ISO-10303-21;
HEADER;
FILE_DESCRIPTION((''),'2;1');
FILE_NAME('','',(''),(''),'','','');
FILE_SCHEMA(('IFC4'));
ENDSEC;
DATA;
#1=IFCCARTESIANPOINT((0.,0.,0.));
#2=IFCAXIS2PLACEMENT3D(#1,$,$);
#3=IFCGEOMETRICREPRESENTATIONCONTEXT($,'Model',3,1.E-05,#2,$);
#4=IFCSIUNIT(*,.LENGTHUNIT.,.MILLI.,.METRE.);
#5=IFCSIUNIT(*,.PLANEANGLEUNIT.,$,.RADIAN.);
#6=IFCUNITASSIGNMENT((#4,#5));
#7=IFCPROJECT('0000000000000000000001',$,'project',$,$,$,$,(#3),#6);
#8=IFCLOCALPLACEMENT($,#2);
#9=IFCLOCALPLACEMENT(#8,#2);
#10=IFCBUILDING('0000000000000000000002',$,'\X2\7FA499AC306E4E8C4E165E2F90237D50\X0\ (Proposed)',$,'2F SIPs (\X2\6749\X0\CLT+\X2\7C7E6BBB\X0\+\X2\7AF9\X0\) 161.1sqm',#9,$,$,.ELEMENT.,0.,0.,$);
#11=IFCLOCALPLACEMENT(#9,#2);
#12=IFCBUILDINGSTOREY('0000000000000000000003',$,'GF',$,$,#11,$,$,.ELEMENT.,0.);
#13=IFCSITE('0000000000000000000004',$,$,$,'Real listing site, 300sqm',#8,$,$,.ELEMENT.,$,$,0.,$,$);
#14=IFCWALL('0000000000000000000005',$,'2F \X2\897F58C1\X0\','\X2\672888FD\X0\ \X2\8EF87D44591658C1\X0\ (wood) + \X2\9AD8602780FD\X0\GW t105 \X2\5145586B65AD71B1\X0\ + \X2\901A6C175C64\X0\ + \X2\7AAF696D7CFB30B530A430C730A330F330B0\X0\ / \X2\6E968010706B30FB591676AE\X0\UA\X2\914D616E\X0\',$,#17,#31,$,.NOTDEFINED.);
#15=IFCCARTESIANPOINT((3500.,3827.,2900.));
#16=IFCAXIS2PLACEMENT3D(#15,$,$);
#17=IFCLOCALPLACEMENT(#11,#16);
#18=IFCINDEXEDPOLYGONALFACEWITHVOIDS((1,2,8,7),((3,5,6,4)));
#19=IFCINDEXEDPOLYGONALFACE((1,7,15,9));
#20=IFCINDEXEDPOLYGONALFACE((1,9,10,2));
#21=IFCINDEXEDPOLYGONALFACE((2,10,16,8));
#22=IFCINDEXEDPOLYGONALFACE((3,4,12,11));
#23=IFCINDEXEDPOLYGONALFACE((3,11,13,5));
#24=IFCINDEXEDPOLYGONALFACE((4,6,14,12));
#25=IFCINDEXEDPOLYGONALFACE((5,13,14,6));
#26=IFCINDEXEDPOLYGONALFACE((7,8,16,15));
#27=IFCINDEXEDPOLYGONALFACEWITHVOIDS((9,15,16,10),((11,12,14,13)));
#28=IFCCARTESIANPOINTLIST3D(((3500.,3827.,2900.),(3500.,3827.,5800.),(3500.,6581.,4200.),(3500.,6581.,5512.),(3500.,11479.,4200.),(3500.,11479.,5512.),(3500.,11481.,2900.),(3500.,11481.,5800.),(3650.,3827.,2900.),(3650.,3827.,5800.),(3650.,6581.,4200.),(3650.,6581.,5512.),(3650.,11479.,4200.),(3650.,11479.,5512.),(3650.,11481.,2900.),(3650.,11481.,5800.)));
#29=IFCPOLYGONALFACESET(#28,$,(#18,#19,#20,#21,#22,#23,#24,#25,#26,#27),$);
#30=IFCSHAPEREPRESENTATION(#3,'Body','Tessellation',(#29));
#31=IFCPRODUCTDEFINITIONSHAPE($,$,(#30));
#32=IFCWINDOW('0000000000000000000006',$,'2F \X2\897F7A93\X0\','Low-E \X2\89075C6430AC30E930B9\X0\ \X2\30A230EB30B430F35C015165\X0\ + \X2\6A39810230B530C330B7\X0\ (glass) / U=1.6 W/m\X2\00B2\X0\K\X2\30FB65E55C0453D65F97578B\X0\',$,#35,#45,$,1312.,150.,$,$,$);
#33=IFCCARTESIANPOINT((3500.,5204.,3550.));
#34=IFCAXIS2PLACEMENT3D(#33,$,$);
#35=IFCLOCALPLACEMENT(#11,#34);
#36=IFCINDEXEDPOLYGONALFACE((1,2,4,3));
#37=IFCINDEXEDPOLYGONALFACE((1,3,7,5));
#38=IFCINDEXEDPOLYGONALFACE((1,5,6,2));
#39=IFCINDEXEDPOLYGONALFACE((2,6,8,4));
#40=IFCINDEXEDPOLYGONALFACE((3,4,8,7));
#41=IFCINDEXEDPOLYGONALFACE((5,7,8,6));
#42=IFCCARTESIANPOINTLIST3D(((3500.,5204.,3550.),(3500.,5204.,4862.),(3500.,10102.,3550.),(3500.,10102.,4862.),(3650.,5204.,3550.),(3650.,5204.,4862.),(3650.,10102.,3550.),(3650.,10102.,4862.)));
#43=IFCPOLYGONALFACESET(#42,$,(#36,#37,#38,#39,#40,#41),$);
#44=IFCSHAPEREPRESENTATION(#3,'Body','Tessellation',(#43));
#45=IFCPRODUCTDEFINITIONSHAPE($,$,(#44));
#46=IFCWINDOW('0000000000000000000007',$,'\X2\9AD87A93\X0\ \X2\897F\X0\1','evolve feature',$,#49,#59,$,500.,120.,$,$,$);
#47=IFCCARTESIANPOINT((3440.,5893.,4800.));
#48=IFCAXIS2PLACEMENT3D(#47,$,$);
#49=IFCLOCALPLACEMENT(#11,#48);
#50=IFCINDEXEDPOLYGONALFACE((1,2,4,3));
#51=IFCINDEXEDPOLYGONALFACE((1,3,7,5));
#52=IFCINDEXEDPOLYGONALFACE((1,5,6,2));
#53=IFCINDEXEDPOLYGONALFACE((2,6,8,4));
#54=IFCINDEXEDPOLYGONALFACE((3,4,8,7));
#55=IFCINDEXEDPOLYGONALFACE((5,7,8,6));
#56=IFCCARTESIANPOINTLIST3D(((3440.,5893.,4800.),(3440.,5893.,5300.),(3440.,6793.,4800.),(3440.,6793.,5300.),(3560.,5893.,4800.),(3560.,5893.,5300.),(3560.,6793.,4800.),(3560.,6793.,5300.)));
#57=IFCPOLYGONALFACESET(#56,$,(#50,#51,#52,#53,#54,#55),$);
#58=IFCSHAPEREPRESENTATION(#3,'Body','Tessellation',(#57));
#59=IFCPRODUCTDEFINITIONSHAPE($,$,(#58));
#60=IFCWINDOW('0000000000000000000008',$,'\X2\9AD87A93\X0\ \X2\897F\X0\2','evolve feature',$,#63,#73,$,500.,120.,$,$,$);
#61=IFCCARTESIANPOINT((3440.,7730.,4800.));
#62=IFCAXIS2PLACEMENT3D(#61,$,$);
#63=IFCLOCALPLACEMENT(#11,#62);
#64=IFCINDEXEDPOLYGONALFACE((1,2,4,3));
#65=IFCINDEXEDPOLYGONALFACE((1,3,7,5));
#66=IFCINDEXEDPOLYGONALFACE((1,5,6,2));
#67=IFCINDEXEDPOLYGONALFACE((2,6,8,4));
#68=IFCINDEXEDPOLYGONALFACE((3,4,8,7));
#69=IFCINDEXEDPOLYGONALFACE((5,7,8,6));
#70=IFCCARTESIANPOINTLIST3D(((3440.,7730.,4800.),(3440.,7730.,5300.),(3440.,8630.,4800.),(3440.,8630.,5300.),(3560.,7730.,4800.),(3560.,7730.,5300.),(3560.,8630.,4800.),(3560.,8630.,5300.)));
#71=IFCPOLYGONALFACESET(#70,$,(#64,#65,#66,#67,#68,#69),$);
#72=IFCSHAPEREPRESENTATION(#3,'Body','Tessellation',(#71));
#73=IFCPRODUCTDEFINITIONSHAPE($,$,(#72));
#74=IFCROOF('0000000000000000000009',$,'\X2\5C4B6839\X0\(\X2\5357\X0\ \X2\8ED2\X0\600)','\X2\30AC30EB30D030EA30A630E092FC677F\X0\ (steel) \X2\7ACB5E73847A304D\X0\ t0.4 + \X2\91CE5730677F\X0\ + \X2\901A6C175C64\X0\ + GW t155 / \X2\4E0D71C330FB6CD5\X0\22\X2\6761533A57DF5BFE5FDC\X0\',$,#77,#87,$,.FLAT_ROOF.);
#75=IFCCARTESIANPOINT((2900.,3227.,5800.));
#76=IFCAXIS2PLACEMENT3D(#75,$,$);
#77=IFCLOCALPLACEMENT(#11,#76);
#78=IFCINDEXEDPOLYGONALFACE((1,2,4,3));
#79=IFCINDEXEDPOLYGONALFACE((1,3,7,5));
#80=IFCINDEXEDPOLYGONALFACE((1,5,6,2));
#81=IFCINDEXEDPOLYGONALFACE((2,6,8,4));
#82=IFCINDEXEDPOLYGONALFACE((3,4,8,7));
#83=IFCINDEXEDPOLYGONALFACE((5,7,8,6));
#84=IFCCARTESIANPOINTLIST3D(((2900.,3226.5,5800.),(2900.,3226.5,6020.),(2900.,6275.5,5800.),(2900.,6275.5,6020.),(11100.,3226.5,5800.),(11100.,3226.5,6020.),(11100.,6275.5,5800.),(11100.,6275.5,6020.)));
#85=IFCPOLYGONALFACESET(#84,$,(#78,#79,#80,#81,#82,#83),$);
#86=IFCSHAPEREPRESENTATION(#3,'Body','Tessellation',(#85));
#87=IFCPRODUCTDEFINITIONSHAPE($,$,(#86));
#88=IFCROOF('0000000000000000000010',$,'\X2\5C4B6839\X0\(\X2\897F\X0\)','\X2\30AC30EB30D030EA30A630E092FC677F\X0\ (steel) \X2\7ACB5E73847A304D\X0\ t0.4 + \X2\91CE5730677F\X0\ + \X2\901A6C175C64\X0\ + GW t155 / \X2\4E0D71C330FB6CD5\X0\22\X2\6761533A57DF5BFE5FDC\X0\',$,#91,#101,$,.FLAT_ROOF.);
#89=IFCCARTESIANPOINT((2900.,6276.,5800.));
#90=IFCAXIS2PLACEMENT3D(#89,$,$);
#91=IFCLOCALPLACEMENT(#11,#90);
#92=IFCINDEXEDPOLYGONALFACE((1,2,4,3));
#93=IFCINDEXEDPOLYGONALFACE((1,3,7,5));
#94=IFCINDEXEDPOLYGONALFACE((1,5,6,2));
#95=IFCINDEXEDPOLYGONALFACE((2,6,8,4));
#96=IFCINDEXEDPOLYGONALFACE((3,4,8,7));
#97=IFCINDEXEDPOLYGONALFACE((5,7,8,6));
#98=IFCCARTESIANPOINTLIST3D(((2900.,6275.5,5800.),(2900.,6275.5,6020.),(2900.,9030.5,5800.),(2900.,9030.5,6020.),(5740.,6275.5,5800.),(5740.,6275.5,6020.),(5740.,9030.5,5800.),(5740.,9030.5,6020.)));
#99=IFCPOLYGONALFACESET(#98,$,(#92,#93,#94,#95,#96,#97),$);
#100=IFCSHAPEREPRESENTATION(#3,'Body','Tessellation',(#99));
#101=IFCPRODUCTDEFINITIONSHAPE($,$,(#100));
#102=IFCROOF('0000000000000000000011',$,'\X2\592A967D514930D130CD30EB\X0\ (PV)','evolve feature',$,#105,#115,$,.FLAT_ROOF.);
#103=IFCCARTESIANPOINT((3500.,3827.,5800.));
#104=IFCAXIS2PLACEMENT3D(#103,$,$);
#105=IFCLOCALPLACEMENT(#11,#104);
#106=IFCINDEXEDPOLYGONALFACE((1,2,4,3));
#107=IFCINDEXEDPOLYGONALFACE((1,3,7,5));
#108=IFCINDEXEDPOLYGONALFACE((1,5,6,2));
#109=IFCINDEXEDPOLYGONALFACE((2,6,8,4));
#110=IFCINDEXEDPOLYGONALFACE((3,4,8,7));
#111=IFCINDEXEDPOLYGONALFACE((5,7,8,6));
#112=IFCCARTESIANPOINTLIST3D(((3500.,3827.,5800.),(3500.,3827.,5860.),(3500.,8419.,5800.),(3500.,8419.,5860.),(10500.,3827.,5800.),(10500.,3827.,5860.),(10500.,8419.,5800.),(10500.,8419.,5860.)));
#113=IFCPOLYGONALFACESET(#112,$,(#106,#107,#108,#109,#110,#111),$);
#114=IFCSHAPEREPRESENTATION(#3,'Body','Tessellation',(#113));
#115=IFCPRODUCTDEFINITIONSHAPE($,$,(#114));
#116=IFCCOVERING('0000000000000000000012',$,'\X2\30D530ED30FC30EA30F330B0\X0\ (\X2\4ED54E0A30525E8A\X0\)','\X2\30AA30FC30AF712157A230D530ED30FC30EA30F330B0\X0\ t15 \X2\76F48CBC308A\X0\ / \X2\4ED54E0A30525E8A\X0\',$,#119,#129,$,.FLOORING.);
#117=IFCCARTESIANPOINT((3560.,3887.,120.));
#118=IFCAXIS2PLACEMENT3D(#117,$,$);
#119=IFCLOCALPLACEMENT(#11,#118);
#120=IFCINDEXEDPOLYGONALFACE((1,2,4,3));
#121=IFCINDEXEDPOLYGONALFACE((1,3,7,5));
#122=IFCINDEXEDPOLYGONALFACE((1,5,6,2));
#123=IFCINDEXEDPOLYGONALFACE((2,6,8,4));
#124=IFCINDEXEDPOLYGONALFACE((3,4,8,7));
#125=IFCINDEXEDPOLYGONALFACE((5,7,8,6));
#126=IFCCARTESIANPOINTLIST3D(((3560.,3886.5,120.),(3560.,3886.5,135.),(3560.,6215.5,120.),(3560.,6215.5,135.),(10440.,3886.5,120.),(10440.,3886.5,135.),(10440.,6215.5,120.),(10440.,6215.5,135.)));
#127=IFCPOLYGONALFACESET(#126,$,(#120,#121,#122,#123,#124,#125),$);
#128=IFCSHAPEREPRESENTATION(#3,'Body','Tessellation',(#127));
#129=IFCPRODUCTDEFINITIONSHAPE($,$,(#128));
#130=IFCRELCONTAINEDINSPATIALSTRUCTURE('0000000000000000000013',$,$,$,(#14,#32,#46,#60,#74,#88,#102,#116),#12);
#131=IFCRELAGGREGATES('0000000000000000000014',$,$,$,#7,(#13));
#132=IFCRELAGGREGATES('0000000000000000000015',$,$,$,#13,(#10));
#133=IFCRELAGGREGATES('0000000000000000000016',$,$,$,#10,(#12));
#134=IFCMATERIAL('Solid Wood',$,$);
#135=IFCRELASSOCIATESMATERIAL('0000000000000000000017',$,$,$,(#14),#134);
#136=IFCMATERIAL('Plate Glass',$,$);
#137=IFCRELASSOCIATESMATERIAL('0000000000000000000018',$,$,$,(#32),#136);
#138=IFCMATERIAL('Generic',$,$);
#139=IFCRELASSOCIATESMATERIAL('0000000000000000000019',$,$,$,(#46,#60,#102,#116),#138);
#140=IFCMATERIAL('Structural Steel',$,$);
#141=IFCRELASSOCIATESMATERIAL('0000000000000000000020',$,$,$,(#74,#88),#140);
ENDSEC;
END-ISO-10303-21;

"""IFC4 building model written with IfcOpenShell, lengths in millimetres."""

from ifc_helpers import new_model, si_unit, frame, frame_2d, origin, place, context, project, spatial, rectangle, extrude, material, element, fill, save


model = new_model("IFC4")

# Units and contexts
model_context = context("Model", 3, precision=1e-05, world=origin())
ifc_project = project(units=[si_unit("LENGTHUNIT", "METRE", prefix="MILLI"), si_unit("PLANEANGLEUNIT", "RADIAN")], contexts=[model_context])

# Site, building, storey
site_placement = place(None, origin())
site = spatial("IfcSite", under=ifc_project, at=site_placement, ObjectType="Real listing site, 300sqm", CompositionType="ELEMENT", RefElevation=0.0)
building_placement = place(site_placement, origin())
building = spatial("IfcBuilding", under=site, at=building_placement, Name="群馬の二世帯連結 (Proposed)", ObjectType="2F SIPs (杉CLT+籾殻+竹) 161.1sqm", CompositionType="ELEMENT", ElevationOfRefHeight=0.0, ElevationOfTerrain=0.0)
storey_placement = place(building_placement, origin())
storey = spatial("IfcBuildingStorey", under=building, at=storey_placement, Name="GF", CompositionType="ELEMENT", Elevation=0.0)

# Shared definitions
ifc_material_1 = material(Name="Solid Wood")
ifc_material_2 = material(Name="Generic")

# Shared definitions
ifc_material_3 = material(Name="Plate Glass")

# Wall, openings, windows
wall_1_placement = place(storey_placement, frame((3500.0, 3827.0, 2900.0)))
wall_1 = element("IfcWall", 1, at=wall_1_placement, inside=storey, material=ifc_material_1, Name="2F 西壁", Description="木製 軸組外壁 (wood) + 高性能GW t105 充填断熱 + 通気層 + 窯業系サイディング / 準耐火・外皮UA配慮", PredefinedType="NOTDEFINED", context=model_context, shape_type="SweptSolid", body=[
    extrude(rectangle(XDim=150.0, YDim=7654.0, at=frame_2d((75.0, 3827.0))), frame((3500.0, 3827.0, 2900.0)), (0.0, 0.0, 1.0), 2900.0),
])
opening_1_placement = place(storey_placement, frame((3500.0, 5204.0, 3550.0)))
opening_1 = element("IfcOpeningElement", 2, at=opening_1_placement, cuts=wall_1, PredefinedType="NOTDEFINED", context=model_context, shape_type="SweptSolid", body=[
    extrude(rectangle(XDim=150.0, YDim=4898.0, at=frame_2d((75.0, 2449.0))), frame((3500.0, 5204.0, 3550.0)), (0.0, 0.0, 1.0), 1312.0),
])
opening_2_placement = place(storey_placement, frame((3440.0, 5893.0, 4800.0)))
opening_2 = element("IfcOpeningElement", 3, at=opening_2_placement, cuts=wall_1, PredefinedType="NOTDEFINED", context=model_context, shape_type="SweptSolid", body=[
    extrude(rectangle(XDim=120.0, YDim=900.0, at=frame_2d((60.0, 450.0))), frame((3440.0, 5893.0, 4800.0)), (0.0, 0.0, 1.0), 500.0),
])
opening_3_placement = place(storey_placement, frame((3440.0, 7730.0, 4800.0)))
opening_3 = element("IfcOpeningElement", 4, at=opening_3_placement, cuts=wall_1, PredefinedType="NOTDEFINED", context=model_context, shape_type="SweptSolid", body=[
    extrude(rectangle(XDim=120.0, YDim=900.0, at=frame_2d((60.0, 450.0))), frame((3440.0, 7730.0, 4800.0)), (0.0, 0.0, 1.0), 500.0),
])
window_1_placement = place(storey_placement, frame((3500.0, 5204.0, 3550.0)))
window_1 = element("IfcWindow", 5, at=window_1_placement, inside=storey, material=ifc_material_3, Name="2F 西窓", Description="Low-E 複層ガラス アルゴン封入 + 樹脂サッシ (glass) / U=1.6 W/m²K・日射取得型", OverallHeight=1312.0, OverallWidth=150.0, context=model_context, shape_type="SweptSolid", body=[
    extrude(rectangle(XDim=150.0, YDim=4898.0, at=frame_2d((75.0, 2449.0))), frame((3500.0, 5204.0, 3550.0)), (0.0, 0.0, 1.0), 1312.0),
])
fill(opening_1, window_1)
window_2_placement = place(storey_placement, frame((3440.0, 5893.0, 4800.0)))
window_2 = element("IfcWindow", 6, at=window_2_placement, inside=storey, material=ifc_material_2, Name="高窓 西1", Description="evolve feature", OverallHeight=500.0, OverallWidth=120.0, context=model_context, shape_type="SweptSolid", body=[
    extrude(rectangle(XDim=120.0, YDim=900.0, at=frame_2d((60.0, 450.0))), frame((3440.0, 5893.0, 4800.0)), (0.0, 0.0, 1.0), 500.0),
])
fill(opening_2, window_2)
window_3_placement = place(storey_placement, frame((3440.0, 7730.0, 4800.0)))
window_3 = element("IfcWindow", 7, at=window_3_placement, inside=storey, material=ifc_material_2, Name="高窓 西2", Description="evolve feature", OverallHeight=500.0, OverallWidth=120.0, context=model_context, shape_type="SweptSolid", body=[
    extrude(rectangle(XDim=120.0, YDim=900.0, at=frame_2d((60.0, 450.0))), frame((3440.0, 7730.0, 4800.0)), (0.0, 0.0, 1.0), 500.0),
])
fill(opening_3, window_3)

# Roofs
ifc_material_4 = material(Name="Structural Steel")
roof_1_placement = place(storey_placement, frame((2900.0, 3227.0, 5800.0)))
element("IfcRoof", 8, at=roof_1_placement, inside=storey, material=ifc_material_4, Name="屋根(南 軒600)", Description="ガルバリウム鋼板 (steel) 立平葺き t0.4 + 野地板 + 通気層 + GW t155 / 不燃・法22条区域対応", PredefinedType="FLAT_ROOF", context=model_context, shape_type="SweptSolid", body=[
    extrude(rectangle(XDim=8200.0, YDim=3049.0, at=frame_2d((4100.0, 1524.0))), frame((2900.0, 3227.0, 5800.0)), (0.0, 0.0, 1.0), 220.0),
])
roof_2_placement = place(storey_placement, frame((2900.0, 6276.0, 5800.0)))
element("IfcRoof", 9, at=roof_2_placement, inside=storey, material=ifc_material_4, Name="屋根(西)", Description="ガルバリウム鋼板 (steel) 立平葺き t0.4 + 野地板 + 通気層 + GW t155 / 不燃・法22条区域対応", PredefinedType="FLAT_ROOF", context=model_context, shape_type="SweptSolid", body=[
    extrude(rectangle(XDim=2840.0, YDim=2755.0, at=frame_2d((1420.0, 1377.0))), frame((2900.0, 6276.0, 5800.0)), (0.0, 0.0, 1.0), 220.0),
])
roof_3_placement = place(storey_placement, frame((3500.0, 3827.0, 5800.0)))
element("IfcRoof", 10, at=roof_3_placement, inside=storey, material=ifc_material_2, Name="太陽光パネル (PV)", Description="evolve feature", PredefinedType="FLAT_ROOF", context=model_context, shape_type="SweptSolid", body=[
    extrude(rectangle(XDim=7000.0, YDim=4592.0, at=frame_2d((3500.0, 2296.0))), frame((3500.0, 3827.0, 5800.0)), (0.0, 0.0, 1.0), 60.0),
])

# Covering
covering_placement = place(storey_placement, frame((3560.0, 3887.0, 120.0)))
element("IfcCovering", 11, at=covering_placement, inside=storey, material=ifc_material_2, Name="フローリング (仕上げ床)", Description="オーク無垢フローリング t15 直貼り / 仕上げ床", PredefinedType="FLOORING", context=model_context, shape_type="SweptSolid", body=[
    extrude(rectangle(XDim=6880.0, YDim=2329.0, at=frame_2d((3440.0, 1164.0))), frame((3560.0, 3887.0, 120.0)), (0.0, 0.0, 1.0), 15.0),
])

save(model, "model.ifc")
